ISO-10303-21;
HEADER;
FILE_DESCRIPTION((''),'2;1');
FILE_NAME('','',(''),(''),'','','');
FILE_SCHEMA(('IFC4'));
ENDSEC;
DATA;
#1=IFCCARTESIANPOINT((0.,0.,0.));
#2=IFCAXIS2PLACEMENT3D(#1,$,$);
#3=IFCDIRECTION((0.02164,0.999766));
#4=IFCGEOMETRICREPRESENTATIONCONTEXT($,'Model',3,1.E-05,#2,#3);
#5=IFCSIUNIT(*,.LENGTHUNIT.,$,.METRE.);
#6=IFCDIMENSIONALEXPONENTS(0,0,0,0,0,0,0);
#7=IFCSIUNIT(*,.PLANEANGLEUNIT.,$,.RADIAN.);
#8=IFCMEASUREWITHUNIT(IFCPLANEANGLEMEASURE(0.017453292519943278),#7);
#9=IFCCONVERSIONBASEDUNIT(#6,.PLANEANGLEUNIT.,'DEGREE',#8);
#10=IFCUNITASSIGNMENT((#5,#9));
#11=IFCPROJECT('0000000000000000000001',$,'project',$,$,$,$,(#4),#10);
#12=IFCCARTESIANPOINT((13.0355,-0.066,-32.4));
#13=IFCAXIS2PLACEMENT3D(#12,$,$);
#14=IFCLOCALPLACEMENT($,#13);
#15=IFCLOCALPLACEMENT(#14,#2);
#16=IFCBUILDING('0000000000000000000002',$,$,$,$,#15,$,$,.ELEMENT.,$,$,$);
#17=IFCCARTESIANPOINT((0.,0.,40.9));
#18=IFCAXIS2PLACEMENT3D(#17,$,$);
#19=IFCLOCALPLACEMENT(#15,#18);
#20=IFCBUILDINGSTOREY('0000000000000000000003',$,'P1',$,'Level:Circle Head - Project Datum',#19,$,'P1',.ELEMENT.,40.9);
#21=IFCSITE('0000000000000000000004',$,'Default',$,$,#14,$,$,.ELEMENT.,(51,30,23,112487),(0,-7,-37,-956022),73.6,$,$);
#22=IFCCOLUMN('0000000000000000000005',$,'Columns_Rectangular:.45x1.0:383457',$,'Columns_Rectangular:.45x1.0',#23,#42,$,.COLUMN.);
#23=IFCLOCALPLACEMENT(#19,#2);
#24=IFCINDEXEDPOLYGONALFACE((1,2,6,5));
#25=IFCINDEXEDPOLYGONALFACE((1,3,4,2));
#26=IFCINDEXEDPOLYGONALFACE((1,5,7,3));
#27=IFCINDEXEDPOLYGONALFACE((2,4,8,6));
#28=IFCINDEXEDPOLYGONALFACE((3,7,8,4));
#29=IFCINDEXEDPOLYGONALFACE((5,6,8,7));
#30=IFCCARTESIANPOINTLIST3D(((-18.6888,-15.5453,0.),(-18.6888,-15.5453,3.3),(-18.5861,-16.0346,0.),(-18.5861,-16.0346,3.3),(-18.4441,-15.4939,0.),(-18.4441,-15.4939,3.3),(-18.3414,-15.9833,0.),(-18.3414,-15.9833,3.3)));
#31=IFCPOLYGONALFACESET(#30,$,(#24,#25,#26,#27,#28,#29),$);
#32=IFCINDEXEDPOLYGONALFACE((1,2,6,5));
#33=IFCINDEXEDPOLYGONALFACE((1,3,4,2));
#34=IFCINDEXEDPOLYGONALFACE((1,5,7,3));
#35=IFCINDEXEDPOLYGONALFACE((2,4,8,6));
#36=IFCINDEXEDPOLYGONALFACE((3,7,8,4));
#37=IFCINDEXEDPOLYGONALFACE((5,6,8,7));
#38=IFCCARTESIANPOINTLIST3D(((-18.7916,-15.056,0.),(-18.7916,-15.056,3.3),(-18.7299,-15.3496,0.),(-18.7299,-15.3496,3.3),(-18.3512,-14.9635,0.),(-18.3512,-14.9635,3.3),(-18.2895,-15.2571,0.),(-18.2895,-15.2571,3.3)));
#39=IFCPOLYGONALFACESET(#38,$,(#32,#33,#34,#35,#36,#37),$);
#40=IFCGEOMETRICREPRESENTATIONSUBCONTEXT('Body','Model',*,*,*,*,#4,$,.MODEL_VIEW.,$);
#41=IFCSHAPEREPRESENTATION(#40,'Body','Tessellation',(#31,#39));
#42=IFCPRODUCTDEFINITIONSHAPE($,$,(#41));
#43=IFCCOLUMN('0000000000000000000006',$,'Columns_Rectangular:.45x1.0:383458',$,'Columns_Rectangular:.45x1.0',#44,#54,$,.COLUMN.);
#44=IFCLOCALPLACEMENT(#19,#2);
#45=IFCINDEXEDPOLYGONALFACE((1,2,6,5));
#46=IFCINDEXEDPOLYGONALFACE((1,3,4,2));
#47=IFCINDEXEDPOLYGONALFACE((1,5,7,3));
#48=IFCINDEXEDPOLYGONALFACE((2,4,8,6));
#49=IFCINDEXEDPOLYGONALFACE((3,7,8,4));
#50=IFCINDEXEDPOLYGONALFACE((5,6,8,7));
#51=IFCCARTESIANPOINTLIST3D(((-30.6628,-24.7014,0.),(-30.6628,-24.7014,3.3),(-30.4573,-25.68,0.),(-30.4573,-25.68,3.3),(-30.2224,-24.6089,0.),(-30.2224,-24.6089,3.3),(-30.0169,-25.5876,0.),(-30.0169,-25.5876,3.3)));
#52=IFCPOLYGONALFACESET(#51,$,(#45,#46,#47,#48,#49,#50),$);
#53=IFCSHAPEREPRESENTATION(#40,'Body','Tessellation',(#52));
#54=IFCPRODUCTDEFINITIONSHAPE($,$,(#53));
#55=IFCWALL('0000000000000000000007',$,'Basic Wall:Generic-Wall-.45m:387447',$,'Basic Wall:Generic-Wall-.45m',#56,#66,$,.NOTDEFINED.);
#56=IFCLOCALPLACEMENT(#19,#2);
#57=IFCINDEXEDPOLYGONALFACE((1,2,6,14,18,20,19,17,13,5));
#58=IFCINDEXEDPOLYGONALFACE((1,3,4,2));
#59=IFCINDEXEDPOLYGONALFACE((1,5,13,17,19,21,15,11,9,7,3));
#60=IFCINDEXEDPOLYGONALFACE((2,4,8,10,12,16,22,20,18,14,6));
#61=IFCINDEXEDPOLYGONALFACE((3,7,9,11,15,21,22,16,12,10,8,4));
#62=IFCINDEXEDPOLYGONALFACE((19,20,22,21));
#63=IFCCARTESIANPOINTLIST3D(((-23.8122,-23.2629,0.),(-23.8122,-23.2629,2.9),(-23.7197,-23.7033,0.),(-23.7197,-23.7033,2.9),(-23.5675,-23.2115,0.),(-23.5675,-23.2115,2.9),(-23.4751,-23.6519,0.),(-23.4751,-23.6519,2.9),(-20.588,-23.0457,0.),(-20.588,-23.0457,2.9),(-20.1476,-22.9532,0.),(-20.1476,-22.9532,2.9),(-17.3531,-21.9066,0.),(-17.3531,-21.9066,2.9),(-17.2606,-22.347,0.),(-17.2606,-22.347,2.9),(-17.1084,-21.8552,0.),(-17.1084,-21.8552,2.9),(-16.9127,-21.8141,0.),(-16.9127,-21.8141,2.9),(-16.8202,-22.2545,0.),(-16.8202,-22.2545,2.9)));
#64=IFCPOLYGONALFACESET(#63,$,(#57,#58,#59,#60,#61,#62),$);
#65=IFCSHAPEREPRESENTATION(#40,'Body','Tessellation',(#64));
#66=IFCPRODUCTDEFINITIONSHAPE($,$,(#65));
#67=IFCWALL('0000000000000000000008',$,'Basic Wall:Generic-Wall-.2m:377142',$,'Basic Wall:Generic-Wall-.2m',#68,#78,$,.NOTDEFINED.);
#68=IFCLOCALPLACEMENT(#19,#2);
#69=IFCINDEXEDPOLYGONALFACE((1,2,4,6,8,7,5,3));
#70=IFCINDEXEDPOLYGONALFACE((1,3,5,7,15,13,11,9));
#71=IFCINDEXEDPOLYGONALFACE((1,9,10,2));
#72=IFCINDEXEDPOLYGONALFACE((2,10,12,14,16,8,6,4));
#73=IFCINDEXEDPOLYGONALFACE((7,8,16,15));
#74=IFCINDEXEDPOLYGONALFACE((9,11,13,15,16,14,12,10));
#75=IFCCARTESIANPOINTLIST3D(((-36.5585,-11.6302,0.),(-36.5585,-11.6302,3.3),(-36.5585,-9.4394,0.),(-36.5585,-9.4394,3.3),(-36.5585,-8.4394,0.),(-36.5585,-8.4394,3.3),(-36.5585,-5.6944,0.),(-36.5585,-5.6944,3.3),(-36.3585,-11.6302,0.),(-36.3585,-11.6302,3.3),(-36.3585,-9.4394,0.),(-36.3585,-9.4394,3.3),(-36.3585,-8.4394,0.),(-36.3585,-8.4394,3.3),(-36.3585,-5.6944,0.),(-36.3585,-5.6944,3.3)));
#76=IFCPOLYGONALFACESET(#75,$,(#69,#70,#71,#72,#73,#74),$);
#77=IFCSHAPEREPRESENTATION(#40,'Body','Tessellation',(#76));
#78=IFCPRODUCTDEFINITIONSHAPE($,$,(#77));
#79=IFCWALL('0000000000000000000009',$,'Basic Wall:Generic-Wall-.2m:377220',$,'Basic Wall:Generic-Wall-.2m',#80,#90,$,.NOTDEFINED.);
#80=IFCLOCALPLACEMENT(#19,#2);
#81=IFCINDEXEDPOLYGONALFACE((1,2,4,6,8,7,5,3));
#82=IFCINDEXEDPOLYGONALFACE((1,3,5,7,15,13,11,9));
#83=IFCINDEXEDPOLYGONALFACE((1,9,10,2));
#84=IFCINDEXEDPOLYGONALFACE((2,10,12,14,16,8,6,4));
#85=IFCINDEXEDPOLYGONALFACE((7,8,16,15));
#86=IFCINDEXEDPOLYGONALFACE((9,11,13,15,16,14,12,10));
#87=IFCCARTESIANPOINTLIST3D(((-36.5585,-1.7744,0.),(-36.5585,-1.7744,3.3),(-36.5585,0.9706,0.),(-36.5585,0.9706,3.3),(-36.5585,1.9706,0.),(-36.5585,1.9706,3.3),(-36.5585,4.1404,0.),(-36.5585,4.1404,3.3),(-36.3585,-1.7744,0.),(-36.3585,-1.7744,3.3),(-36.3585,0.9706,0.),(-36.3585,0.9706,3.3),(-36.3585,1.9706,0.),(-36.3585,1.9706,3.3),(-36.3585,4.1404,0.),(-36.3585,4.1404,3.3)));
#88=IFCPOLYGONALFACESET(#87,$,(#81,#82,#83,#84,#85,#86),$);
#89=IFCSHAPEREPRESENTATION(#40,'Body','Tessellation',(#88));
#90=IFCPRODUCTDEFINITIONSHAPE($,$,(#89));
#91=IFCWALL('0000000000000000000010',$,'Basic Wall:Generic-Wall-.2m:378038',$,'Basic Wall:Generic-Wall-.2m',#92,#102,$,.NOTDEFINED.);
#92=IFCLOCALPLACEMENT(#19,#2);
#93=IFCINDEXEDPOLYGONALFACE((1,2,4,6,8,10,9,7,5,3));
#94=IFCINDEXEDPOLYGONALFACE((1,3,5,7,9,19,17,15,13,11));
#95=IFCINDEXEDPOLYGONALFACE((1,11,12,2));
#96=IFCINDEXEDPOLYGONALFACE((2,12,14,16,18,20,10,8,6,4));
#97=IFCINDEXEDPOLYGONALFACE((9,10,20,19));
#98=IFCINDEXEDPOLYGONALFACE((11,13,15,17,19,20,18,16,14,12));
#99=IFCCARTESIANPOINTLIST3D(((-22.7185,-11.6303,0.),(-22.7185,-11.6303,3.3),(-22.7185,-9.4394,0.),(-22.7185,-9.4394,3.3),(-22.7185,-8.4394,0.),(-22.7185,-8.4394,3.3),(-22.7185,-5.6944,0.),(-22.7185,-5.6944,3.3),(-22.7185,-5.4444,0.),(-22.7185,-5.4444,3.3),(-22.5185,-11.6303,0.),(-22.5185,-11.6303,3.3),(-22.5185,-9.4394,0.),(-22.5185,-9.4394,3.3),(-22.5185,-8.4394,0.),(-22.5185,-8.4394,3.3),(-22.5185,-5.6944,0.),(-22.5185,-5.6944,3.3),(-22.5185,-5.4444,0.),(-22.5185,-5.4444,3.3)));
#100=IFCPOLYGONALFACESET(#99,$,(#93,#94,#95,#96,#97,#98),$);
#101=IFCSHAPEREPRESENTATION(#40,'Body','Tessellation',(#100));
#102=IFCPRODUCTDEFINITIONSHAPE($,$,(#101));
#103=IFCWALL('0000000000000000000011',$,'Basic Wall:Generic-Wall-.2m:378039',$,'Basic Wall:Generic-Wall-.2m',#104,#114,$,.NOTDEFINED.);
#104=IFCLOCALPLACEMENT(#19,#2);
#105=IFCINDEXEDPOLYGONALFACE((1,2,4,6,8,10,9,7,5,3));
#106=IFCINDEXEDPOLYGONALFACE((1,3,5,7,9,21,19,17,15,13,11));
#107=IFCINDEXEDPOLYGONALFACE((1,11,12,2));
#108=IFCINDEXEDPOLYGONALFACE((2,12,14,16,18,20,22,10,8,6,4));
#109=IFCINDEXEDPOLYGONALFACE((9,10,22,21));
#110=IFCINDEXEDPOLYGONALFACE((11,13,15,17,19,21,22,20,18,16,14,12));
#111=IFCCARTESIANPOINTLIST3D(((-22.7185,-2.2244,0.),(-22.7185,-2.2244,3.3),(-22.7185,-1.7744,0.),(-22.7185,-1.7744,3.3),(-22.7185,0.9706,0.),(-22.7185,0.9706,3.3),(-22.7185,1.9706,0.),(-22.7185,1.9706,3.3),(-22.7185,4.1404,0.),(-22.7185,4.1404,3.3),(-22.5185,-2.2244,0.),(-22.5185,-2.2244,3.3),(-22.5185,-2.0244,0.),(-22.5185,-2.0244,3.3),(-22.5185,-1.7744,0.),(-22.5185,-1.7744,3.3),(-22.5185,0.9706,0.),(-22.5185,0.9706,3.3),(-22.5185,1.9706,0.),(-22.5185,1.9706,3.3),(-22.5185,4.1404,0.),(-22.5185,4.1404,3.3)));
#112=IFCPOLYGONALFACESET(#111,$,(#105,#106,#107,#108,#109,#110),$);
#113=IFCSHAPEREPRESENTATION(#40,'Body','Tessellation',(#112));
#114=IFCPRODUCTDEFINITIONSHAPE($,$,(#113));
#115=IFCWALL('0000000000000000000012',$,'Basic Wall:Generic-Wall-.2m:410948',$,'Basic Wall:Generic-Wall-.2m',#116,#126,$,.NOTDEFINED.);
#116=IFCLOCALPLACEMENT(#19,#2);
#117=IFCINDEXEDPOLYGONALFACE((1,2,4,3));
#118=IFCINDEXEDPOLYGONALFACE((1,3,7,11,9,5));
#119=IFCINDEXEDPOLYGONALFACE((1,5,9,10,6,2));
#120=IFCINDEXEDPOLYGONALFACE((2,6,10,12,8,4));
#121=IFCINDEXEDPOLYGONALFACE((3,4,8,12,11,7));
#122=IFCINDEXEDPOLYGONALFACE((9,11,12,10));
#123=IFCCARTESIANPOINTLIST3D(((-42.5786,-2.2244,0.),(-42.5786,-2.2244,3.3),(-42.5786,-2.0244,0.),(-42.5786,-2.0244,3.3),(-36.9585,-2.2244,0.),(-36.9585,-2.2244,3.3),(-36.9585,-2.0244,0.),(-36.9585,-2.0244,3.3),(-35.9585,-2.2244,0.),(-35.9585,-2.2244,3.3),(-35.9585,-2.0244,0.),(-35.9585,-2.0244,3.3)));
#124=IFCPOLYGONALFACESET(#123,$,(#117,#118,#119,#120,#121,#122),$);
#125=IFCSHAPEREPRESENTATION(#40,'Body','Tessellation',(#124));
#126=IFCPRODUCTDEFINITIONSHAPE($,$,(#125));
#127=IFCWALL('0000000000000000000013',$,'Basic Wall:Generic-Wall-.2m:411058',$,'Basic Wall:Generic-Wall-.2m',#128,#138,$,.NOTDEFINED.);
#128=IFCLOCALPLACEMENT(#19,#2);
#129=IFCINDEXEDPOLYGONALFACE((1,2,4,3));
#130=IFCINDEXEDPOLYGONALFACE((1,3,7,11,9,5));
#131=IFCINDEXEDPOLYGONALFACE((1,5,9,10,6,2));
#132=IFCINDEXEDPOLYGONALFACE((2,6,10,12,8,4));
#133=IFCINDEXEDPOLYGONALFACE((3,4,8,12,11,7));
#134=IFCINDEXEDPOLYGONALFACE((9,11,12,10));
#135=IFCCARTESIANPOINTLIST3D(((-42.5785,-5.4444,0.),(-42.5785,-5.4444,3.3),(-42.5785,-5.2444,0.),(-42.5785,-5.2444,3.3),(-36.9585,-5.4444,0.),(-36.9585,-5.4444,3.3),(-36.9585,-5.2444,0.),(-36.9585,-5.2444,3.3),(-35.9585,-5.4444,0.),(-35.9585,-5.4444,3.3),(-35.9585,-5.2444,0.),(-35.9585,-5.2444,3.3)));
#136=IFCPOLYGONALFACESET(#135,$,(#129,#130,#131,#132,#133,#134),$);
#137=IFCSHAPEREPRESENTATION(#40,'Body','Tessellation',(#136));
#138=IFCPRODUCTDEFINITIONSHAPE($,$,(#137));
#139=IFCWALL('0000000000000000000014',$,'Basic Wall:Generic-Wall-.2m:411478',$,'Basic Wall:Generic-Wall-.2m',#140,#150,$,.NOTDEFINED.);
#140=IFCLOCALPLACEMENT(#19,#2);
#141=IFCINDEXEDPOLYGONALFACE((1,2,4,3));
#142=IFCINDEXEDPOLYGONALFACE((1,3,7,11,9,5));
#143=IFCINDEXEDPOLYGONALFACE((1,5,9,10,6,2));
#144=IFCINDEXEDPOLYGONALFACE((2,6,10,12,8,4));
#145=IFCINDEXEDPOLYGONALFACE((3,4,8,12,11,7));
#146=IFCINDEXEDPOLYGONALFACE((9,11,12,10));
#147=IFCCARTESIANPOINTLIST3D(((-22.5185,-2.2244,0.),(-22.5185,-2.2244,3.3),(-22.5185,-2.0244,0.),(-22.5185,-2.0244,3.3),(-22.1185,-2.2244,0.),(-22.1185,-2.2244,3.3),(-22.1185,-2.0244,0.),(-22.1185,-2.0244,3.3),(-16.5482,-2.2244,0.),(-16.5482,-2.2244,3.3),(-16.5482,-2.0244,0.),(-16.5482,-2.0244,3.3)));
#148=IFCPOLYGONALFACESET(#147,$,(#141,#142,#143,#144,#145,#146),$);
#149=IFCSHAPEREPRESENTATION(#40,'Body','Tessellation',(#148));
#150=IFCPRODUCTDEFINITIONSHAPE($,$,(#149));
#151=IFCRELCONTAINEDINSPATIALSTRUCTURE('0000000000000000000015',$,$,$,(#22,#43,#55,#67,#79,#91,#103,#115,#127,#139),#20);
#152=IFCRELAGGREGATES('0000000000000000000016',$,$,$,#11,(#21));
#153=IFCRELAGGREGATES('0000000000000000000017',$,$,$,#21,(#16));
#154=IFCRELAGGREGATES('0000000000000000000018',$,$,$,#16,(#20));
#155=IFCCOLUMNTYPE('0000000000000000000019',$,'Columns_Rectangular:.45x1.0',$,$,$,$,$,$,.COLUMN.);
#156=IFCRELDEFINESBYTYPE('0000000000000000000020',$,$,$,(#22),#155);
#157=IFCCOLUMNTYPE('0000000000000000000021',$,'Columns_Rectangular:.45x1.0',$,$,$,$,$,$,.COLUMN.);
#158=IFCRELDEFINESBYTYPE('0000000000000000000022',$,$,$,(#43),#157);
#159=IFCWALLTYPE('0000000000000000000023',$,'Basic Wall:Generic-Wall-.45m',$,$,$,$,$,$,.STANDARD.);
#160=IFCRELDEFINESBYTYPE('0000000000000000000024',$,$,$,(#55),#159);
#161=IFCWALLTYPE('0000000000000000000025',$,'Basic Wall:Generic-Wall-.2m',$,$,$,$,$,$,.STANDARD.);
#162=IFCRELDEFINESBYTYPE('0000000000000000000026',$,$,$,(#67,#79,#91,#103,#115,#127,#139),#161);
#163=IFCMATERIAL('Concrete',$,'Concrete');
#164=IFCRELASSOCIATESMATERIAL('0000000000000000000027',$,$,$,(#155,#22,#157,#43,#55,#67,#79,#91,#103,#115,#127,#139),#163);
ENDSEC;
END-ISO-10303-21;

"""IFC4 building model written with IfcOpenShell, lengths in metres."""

from ifc_helpers import new_model, entity, si_unit, converted_unit, direction, frame, origin, place, context, subcontext, project, spatial, indexed_curve, outline, extrude, source, transform, mapped, material, type_object, type_shapes, element, save


model = new_model("IFC4")

# Units and contexts
model_context = context("Model", 3, precision=1e-05, world=origin(), true_north=direction((0.02164, 0.999766)))
body_context = subcontext(model_context, "Body", "Model", "MODEL_VIEW")
ifc_project = project(units=[si_unit("LENGTHUNIT", "METRE"), converted_unit("PLANEANGLEUNIT", "DEGREE", entity("IfcPlaneAngleMeasure", 0.017453292519943278), si_unit("PLANEANGLEUNIT", "RADIAN"), dimensions=[0, 0, 0, 0, 0, 0, 0])], contexts=[model_context])

# Site, building, storey
site_placement = place(None, frame((13.0355, -0.066, -32.4)))
site = spatial("IfcSite", under=ifc_project, at=site_placement, Name="Default", CompositionType="ELEMENT", RefLatitude=(51, 30, 23, 112487), RefLongitude=(0, -7, -37, -956022), RefElevation=73.6)
building_placement = place(site_placement, origin())
building = spatial("IfcBuilding", under=site, at=building_placement, CompositionType="ELEMENT")
storey_placement = place(building_placement, frame((0.0, 0.0, 40.9)))
storey = spatial("IfcBuildingStorey", under=building, at=storey_placement, Name="P1", ObjectType="Level:Circle Head - Project Datum", LongName="P1", CompositionType="ELEMENT", Elevation=40.9)

# Columns
ifc_material = material(Name="Concrete", Category="Concrete")
column_type_1 = type_object("IfcColumnType", Name="Columns_Rectangular:.45x1.0", PredefinedType="COLUMN", material=ifc_material)
shared_shape_1 = source(origin(), body_context, "Body", "SweptSolid", [
    extrude(outline(indexed_curve([(-0.125, -0.25), (0.125, -0.25), (0.125, 0.25), (-0.125, 0.25), (-0.125, -0.25)], self_intersect=False)), frame((-18.5151, -15.7643, 40.9), z_axis=(0.0, 0.0, 1.0), x_axis=(0.978657, 0.2055, 0.0)), (0.0, 0.0, 1.0), 3.3),
    extrude(outline(indexed_curve([(-0.15, -0.225), (0.15, -0.225), (0.15, 0.225), (-0.15, 0.225), (-0.15, -0.225)], self_intersect=False)), frame((-18.5405, -15.1565, 40.9), z_axis=(0.0, 0.0, 1.0), x_axis=(0.2055, -0.978657, 0.0)), (0.0, 0.0, 1.0), 3.3),
])
type_shapes(column_type_1, [shared_shape_1])
column_1_placement = place(storey_placement, frame((0.0, 0.0, -40.9)))
element("IfcColumn", 1, at=column_1_placement, inside=storey, type_object=column_type_1, material=ifc_material, Name="Columns_Rectangular:.45x1.0:383457", ObjectType="Columns_Rectangular:.45x1.0", PredefinedType="COLUMN", context=body_context, shape_type="MappedRepresentation", body=[
    mapped(shared_shape_1, transform((0.0, 0.0, 0.0), scale=1.0)),
])
column_type_2 = type_object("IfcColumnType", Name="Columns_Rectangular:.45x1.0", PredefinedType="COLUMN", material=ifc_material)
shared_shape_2 = source(origin(), body_context, "Body", "SweptSolid", [
    extrude(outline(indexed_curve([(-0.5, -0.225), (0.5, -0.225), (0.5, 0.225), (-0.5, 0.225), (-0.5, -0.225)], self_intersect=False)), frame((-30.3399, -25.1445, 40.9), z_axis=(0.0, 0.0, 1.0), x_axis=(-0.2055, 0.978657, 0.0)), (0.0, 0.0, 1.0), 3.3),
])
type_shapes(column_type_2, [shared_shape_2])
column_2_placement = place(storey_placement, frame((0.0, 0.0, -40.9)))
element("IfcColumn", 2, at=column_2_placement, inside=storey, type_object=column_type_2, material=ifc_material, Name="Columns_Rectangular:.45x1.0:383458", ObjectType="Columns_Rectangular:.45x1.0", PredefinedType="COLUMN", context=body_context, shape_type="MappedRepresentation", body=[
    mapped(shared_shape_2, transform((0.0, 0.0, 0.0), scale=1.0)),
])

# Walls
wall_type_1 = type_object("IfcWallType", Name="Basic Wall:Generic-Wall-.45m", PredefinedType="STANDARD")
wall_1_placement = place(storey_placement, frame((-23.766, -23.4831, 0.0), z_axis=(0.0, 0.0, 1.0), x_axis=(0.978657, 0.2055, 0.0)))
element("IfcWall", 3, at=wall_1_placement, inside=storey, type_object=wall_type_1, material=ifc_material, Name="Basic Wall:Generic-Wall-.45m:387447", ObjectType="Basic Wall:Generic-Wall-.45m", PredefinedType="NOTDEFINED", context=body_context, shape_type="SweptSolid", body=[
    extrude(outline(indexed_curve([(7.05, -0.225), (7.05, 0.225), (6.85, 0.225), (6.6, 0.225), (0.25, 0.225), (0.0, 0.225), (0.0, -0.225), (0.25, -0.225), (3.2, -0.225), (3.65, -0.225), (6.6, -0.225), (7.05, -0.225)], self_intersect=False)), origin(), (0.0, 0.0, 1.0), 2.9),
])
wall_type_2 = type_object("IfcWallType", Name="Basic Wall:Generic-Wall-.2m", PredefinedType="STANDARD")
wall_2_placement = place(storey_placement, frame((-36.4585, -5.6944, 0.0), z_axis=(0.0, 0.0, 1.0), x_axis=(0.0, -1.0, 0.0)))
element("IfcWall", 4, at=wall_2_placement, inside=storey, type_object=wall_type_2, material=ifc_material, Name="Basic Wall:Generic-Wall-.2m:377142", ObjectType="Basic Wall:Generic-Wall-.2m", PredefinedType="NOTDEFINED", context=body_context, shape_type="SweptSolid", body=[
    extrude(outline(indexed_curve([(5.9357, -0.1), (5.9357, 0.1), (3.745, 0.1), (2.745, 0.1), (0.0, 0.1), (0.0, -0.1), (2.745, -0.1), (3.745, -0.1), (5.9357, -0.1)], self_intersect=False)), origin(), (0.0, 0.0, 1.0), 3.3),
])
wall_3_placement = place(storey_placement, frame((-36.4585, -1.7744, 0.0), z_axis=(0.0, 0.0, 1.0), x_axis=(0.0, 1.0, 0.0)))
element("IfcWall", 5, at=wall_3_placement, inside=storey, type_object=wall_type_2, material=ifc_material, Name="Basic Wall:Generic-Wall-.2m:377220", ObjectType="Basic Wall:Generic-Wall-.2m", PredefinedType="NOTDEFINED", context=body_context, shape_type="SweptSolid", body=[
    extrude(outline(indexed_curve([(5.9149, -0.1), (5.9149, 0.1), (3.745, 0.1), (2.745, 0.1), (0.0, 0.1), (0.0, -0.1), (2.745, -0.1), (3.745, -0.1), (5.9149, -0.1)], self_intersect=False)), origin(), (0.0, 0.0, 1.0), 3.3),
])
wall_4_placement = place(storey_placement, frame((-22.6185, -5.4444, 0.0), z_axis=(0.0, 0.0, 1.0), x_axis=(0.0, -1.0, 0.0)))
element("IfcWall", 6, at=wall_4_placement, inside=storey, type_object=wall_type_2, material=ifc_material, Name="Basic Wall:Generic-Wall-.2m:378038", ObjectType="Basic Wall:Generic-Wall-.2m", PredefinedType="NOTDEFINED", context=body_context, shape_type="SweptSolid", body=[
    extrude(outline(indexed_curve([(6.1858, -0.1), (6.1859, 0.1), (3.995, 0.1), (2.995, 0.1), (0.25, 0.1), (0.0, 0.1), (0.0, -0.1), (0.25, -0.1), (2.995, -0.1), (3.995, -0.1), (6.1858, -0.1)], self_intersect=False)), origin(), (0.0, 0.0, 1.0), 3.3),
])
wall_5_placement = place(storey_placement, frame((-22.6185, -2.2244, 0.0), z_axis=(0.0, 0.0, 1.0), x_axis=(0.0, 1.0, 0.0)))
element("IfcWall", 7, at=wall_5_placement, inside=storey, type_object=wall_type_2, material=ifc_material, Name="Basic Wall:Generic-Wall-.2m:378039", ObjectType="Basic Wall:Generic-Wall-.2m", PredefinedType="NOTDEFINED", context=body_context, shape_type="SweptSolid", body=[
    extrude(outline(indexed_curve([(6.3649, -0.1), (6.3649, 0.1), (4.195, 0.1), (3.195, 0.1), (0.45, 0.1), (0.0, 0.1), (0.0, -0.1), (0.2, -0.1), (0.45, -0.1), (3.195, -0.1), (4.195, -0.1), (6.3649, -0.1)], self_intersect=False)), origin(), (0.0, 0.0, 1.0), 3.3),
])
wall_6_placement = place(storey_placement, frame((-35.9585, -2.1244, 0.0), z_axis=(0.0, 0.0, 1.0), x_axis=(-1.0, 0.0, 0.0)))
element("IfcWall", 8, at=wall_6_placement, inside=storey, type_object=wall_type_2, material=ifc_material, Name="Basic Wall:Generic-Wall-.2m:410948", ObjectType="Basic Wall:Generic-Wall-.2m", PredefinedType="NOTDEFINED", context=body_context, shape_type="SweptSolid", body=[
    extrude(outline(indexed_curve([(6.6201, -0.1), (6.6201, 0.1), (1.0, 0.1), (0.0, 0.1), (0.0, -0.1), (1.0, -0.1), (6.6201, -0.1)], self_intersect=False)), origin(), (0.0, 0.0, 1.0), 3.3),
])
wall_7_placement = place(storey_placement, frame((-35.9585, -5.3444, 0.0), z_axis=(0.0, 0.0, 1.0), x_axis=(-1.0, 0.0, 0.0)))
element("IfcWall", 9, at=wall_7_placement, inside=storey, type_object=wall_type_2, material=ifc_material, Name="Basic Wall:Generic-Wall-.2m:411058", ObjectType="Basic Wall:Generic-Wall-.2m", PredefinedType="NOTDEFINED", context=body_context, shape_type="SweptSolid", body=[
    extrude(outline(indexed_curve([(6.6201, -0.1), (6.6201, 0.1), (1.0, 0.1), (0.0, 0.1), (0.0, -0.1), (1.0, -0.1), (6.6201, -0.1)], self_intersect=False)), origin(), (0.0, 0.0, 1.0), 3.3),
])
wall_8_placement = place(storey_placement, frame((-22.5185, -2.1244, 0.0)))
element("IfcWall", 10, at=wall_8_placement, inside=storey, type_object=wall_type_2, material=ifc_material, Name="Basic Wall:Generic-Wall-.2m:411478", ObjectType="Basic Wall:Generic-Wall-.2m", PredefinedType="NOTDEFINED", context=body_context, shape_type="SweptSolid", body=[
    extrude(outline(indexed_curve([(5.9702, -0.1), (5.9702, 0.1), (0.4, 0.1), (0.0, 0.1), (0.0, -0.1), (0.4, -0.1), (5.9702, -0.1)], self_intersect=False)), origin(), (0.0, 0.0, 1.0), 3.3),
])

save(model, "model.ifc")
